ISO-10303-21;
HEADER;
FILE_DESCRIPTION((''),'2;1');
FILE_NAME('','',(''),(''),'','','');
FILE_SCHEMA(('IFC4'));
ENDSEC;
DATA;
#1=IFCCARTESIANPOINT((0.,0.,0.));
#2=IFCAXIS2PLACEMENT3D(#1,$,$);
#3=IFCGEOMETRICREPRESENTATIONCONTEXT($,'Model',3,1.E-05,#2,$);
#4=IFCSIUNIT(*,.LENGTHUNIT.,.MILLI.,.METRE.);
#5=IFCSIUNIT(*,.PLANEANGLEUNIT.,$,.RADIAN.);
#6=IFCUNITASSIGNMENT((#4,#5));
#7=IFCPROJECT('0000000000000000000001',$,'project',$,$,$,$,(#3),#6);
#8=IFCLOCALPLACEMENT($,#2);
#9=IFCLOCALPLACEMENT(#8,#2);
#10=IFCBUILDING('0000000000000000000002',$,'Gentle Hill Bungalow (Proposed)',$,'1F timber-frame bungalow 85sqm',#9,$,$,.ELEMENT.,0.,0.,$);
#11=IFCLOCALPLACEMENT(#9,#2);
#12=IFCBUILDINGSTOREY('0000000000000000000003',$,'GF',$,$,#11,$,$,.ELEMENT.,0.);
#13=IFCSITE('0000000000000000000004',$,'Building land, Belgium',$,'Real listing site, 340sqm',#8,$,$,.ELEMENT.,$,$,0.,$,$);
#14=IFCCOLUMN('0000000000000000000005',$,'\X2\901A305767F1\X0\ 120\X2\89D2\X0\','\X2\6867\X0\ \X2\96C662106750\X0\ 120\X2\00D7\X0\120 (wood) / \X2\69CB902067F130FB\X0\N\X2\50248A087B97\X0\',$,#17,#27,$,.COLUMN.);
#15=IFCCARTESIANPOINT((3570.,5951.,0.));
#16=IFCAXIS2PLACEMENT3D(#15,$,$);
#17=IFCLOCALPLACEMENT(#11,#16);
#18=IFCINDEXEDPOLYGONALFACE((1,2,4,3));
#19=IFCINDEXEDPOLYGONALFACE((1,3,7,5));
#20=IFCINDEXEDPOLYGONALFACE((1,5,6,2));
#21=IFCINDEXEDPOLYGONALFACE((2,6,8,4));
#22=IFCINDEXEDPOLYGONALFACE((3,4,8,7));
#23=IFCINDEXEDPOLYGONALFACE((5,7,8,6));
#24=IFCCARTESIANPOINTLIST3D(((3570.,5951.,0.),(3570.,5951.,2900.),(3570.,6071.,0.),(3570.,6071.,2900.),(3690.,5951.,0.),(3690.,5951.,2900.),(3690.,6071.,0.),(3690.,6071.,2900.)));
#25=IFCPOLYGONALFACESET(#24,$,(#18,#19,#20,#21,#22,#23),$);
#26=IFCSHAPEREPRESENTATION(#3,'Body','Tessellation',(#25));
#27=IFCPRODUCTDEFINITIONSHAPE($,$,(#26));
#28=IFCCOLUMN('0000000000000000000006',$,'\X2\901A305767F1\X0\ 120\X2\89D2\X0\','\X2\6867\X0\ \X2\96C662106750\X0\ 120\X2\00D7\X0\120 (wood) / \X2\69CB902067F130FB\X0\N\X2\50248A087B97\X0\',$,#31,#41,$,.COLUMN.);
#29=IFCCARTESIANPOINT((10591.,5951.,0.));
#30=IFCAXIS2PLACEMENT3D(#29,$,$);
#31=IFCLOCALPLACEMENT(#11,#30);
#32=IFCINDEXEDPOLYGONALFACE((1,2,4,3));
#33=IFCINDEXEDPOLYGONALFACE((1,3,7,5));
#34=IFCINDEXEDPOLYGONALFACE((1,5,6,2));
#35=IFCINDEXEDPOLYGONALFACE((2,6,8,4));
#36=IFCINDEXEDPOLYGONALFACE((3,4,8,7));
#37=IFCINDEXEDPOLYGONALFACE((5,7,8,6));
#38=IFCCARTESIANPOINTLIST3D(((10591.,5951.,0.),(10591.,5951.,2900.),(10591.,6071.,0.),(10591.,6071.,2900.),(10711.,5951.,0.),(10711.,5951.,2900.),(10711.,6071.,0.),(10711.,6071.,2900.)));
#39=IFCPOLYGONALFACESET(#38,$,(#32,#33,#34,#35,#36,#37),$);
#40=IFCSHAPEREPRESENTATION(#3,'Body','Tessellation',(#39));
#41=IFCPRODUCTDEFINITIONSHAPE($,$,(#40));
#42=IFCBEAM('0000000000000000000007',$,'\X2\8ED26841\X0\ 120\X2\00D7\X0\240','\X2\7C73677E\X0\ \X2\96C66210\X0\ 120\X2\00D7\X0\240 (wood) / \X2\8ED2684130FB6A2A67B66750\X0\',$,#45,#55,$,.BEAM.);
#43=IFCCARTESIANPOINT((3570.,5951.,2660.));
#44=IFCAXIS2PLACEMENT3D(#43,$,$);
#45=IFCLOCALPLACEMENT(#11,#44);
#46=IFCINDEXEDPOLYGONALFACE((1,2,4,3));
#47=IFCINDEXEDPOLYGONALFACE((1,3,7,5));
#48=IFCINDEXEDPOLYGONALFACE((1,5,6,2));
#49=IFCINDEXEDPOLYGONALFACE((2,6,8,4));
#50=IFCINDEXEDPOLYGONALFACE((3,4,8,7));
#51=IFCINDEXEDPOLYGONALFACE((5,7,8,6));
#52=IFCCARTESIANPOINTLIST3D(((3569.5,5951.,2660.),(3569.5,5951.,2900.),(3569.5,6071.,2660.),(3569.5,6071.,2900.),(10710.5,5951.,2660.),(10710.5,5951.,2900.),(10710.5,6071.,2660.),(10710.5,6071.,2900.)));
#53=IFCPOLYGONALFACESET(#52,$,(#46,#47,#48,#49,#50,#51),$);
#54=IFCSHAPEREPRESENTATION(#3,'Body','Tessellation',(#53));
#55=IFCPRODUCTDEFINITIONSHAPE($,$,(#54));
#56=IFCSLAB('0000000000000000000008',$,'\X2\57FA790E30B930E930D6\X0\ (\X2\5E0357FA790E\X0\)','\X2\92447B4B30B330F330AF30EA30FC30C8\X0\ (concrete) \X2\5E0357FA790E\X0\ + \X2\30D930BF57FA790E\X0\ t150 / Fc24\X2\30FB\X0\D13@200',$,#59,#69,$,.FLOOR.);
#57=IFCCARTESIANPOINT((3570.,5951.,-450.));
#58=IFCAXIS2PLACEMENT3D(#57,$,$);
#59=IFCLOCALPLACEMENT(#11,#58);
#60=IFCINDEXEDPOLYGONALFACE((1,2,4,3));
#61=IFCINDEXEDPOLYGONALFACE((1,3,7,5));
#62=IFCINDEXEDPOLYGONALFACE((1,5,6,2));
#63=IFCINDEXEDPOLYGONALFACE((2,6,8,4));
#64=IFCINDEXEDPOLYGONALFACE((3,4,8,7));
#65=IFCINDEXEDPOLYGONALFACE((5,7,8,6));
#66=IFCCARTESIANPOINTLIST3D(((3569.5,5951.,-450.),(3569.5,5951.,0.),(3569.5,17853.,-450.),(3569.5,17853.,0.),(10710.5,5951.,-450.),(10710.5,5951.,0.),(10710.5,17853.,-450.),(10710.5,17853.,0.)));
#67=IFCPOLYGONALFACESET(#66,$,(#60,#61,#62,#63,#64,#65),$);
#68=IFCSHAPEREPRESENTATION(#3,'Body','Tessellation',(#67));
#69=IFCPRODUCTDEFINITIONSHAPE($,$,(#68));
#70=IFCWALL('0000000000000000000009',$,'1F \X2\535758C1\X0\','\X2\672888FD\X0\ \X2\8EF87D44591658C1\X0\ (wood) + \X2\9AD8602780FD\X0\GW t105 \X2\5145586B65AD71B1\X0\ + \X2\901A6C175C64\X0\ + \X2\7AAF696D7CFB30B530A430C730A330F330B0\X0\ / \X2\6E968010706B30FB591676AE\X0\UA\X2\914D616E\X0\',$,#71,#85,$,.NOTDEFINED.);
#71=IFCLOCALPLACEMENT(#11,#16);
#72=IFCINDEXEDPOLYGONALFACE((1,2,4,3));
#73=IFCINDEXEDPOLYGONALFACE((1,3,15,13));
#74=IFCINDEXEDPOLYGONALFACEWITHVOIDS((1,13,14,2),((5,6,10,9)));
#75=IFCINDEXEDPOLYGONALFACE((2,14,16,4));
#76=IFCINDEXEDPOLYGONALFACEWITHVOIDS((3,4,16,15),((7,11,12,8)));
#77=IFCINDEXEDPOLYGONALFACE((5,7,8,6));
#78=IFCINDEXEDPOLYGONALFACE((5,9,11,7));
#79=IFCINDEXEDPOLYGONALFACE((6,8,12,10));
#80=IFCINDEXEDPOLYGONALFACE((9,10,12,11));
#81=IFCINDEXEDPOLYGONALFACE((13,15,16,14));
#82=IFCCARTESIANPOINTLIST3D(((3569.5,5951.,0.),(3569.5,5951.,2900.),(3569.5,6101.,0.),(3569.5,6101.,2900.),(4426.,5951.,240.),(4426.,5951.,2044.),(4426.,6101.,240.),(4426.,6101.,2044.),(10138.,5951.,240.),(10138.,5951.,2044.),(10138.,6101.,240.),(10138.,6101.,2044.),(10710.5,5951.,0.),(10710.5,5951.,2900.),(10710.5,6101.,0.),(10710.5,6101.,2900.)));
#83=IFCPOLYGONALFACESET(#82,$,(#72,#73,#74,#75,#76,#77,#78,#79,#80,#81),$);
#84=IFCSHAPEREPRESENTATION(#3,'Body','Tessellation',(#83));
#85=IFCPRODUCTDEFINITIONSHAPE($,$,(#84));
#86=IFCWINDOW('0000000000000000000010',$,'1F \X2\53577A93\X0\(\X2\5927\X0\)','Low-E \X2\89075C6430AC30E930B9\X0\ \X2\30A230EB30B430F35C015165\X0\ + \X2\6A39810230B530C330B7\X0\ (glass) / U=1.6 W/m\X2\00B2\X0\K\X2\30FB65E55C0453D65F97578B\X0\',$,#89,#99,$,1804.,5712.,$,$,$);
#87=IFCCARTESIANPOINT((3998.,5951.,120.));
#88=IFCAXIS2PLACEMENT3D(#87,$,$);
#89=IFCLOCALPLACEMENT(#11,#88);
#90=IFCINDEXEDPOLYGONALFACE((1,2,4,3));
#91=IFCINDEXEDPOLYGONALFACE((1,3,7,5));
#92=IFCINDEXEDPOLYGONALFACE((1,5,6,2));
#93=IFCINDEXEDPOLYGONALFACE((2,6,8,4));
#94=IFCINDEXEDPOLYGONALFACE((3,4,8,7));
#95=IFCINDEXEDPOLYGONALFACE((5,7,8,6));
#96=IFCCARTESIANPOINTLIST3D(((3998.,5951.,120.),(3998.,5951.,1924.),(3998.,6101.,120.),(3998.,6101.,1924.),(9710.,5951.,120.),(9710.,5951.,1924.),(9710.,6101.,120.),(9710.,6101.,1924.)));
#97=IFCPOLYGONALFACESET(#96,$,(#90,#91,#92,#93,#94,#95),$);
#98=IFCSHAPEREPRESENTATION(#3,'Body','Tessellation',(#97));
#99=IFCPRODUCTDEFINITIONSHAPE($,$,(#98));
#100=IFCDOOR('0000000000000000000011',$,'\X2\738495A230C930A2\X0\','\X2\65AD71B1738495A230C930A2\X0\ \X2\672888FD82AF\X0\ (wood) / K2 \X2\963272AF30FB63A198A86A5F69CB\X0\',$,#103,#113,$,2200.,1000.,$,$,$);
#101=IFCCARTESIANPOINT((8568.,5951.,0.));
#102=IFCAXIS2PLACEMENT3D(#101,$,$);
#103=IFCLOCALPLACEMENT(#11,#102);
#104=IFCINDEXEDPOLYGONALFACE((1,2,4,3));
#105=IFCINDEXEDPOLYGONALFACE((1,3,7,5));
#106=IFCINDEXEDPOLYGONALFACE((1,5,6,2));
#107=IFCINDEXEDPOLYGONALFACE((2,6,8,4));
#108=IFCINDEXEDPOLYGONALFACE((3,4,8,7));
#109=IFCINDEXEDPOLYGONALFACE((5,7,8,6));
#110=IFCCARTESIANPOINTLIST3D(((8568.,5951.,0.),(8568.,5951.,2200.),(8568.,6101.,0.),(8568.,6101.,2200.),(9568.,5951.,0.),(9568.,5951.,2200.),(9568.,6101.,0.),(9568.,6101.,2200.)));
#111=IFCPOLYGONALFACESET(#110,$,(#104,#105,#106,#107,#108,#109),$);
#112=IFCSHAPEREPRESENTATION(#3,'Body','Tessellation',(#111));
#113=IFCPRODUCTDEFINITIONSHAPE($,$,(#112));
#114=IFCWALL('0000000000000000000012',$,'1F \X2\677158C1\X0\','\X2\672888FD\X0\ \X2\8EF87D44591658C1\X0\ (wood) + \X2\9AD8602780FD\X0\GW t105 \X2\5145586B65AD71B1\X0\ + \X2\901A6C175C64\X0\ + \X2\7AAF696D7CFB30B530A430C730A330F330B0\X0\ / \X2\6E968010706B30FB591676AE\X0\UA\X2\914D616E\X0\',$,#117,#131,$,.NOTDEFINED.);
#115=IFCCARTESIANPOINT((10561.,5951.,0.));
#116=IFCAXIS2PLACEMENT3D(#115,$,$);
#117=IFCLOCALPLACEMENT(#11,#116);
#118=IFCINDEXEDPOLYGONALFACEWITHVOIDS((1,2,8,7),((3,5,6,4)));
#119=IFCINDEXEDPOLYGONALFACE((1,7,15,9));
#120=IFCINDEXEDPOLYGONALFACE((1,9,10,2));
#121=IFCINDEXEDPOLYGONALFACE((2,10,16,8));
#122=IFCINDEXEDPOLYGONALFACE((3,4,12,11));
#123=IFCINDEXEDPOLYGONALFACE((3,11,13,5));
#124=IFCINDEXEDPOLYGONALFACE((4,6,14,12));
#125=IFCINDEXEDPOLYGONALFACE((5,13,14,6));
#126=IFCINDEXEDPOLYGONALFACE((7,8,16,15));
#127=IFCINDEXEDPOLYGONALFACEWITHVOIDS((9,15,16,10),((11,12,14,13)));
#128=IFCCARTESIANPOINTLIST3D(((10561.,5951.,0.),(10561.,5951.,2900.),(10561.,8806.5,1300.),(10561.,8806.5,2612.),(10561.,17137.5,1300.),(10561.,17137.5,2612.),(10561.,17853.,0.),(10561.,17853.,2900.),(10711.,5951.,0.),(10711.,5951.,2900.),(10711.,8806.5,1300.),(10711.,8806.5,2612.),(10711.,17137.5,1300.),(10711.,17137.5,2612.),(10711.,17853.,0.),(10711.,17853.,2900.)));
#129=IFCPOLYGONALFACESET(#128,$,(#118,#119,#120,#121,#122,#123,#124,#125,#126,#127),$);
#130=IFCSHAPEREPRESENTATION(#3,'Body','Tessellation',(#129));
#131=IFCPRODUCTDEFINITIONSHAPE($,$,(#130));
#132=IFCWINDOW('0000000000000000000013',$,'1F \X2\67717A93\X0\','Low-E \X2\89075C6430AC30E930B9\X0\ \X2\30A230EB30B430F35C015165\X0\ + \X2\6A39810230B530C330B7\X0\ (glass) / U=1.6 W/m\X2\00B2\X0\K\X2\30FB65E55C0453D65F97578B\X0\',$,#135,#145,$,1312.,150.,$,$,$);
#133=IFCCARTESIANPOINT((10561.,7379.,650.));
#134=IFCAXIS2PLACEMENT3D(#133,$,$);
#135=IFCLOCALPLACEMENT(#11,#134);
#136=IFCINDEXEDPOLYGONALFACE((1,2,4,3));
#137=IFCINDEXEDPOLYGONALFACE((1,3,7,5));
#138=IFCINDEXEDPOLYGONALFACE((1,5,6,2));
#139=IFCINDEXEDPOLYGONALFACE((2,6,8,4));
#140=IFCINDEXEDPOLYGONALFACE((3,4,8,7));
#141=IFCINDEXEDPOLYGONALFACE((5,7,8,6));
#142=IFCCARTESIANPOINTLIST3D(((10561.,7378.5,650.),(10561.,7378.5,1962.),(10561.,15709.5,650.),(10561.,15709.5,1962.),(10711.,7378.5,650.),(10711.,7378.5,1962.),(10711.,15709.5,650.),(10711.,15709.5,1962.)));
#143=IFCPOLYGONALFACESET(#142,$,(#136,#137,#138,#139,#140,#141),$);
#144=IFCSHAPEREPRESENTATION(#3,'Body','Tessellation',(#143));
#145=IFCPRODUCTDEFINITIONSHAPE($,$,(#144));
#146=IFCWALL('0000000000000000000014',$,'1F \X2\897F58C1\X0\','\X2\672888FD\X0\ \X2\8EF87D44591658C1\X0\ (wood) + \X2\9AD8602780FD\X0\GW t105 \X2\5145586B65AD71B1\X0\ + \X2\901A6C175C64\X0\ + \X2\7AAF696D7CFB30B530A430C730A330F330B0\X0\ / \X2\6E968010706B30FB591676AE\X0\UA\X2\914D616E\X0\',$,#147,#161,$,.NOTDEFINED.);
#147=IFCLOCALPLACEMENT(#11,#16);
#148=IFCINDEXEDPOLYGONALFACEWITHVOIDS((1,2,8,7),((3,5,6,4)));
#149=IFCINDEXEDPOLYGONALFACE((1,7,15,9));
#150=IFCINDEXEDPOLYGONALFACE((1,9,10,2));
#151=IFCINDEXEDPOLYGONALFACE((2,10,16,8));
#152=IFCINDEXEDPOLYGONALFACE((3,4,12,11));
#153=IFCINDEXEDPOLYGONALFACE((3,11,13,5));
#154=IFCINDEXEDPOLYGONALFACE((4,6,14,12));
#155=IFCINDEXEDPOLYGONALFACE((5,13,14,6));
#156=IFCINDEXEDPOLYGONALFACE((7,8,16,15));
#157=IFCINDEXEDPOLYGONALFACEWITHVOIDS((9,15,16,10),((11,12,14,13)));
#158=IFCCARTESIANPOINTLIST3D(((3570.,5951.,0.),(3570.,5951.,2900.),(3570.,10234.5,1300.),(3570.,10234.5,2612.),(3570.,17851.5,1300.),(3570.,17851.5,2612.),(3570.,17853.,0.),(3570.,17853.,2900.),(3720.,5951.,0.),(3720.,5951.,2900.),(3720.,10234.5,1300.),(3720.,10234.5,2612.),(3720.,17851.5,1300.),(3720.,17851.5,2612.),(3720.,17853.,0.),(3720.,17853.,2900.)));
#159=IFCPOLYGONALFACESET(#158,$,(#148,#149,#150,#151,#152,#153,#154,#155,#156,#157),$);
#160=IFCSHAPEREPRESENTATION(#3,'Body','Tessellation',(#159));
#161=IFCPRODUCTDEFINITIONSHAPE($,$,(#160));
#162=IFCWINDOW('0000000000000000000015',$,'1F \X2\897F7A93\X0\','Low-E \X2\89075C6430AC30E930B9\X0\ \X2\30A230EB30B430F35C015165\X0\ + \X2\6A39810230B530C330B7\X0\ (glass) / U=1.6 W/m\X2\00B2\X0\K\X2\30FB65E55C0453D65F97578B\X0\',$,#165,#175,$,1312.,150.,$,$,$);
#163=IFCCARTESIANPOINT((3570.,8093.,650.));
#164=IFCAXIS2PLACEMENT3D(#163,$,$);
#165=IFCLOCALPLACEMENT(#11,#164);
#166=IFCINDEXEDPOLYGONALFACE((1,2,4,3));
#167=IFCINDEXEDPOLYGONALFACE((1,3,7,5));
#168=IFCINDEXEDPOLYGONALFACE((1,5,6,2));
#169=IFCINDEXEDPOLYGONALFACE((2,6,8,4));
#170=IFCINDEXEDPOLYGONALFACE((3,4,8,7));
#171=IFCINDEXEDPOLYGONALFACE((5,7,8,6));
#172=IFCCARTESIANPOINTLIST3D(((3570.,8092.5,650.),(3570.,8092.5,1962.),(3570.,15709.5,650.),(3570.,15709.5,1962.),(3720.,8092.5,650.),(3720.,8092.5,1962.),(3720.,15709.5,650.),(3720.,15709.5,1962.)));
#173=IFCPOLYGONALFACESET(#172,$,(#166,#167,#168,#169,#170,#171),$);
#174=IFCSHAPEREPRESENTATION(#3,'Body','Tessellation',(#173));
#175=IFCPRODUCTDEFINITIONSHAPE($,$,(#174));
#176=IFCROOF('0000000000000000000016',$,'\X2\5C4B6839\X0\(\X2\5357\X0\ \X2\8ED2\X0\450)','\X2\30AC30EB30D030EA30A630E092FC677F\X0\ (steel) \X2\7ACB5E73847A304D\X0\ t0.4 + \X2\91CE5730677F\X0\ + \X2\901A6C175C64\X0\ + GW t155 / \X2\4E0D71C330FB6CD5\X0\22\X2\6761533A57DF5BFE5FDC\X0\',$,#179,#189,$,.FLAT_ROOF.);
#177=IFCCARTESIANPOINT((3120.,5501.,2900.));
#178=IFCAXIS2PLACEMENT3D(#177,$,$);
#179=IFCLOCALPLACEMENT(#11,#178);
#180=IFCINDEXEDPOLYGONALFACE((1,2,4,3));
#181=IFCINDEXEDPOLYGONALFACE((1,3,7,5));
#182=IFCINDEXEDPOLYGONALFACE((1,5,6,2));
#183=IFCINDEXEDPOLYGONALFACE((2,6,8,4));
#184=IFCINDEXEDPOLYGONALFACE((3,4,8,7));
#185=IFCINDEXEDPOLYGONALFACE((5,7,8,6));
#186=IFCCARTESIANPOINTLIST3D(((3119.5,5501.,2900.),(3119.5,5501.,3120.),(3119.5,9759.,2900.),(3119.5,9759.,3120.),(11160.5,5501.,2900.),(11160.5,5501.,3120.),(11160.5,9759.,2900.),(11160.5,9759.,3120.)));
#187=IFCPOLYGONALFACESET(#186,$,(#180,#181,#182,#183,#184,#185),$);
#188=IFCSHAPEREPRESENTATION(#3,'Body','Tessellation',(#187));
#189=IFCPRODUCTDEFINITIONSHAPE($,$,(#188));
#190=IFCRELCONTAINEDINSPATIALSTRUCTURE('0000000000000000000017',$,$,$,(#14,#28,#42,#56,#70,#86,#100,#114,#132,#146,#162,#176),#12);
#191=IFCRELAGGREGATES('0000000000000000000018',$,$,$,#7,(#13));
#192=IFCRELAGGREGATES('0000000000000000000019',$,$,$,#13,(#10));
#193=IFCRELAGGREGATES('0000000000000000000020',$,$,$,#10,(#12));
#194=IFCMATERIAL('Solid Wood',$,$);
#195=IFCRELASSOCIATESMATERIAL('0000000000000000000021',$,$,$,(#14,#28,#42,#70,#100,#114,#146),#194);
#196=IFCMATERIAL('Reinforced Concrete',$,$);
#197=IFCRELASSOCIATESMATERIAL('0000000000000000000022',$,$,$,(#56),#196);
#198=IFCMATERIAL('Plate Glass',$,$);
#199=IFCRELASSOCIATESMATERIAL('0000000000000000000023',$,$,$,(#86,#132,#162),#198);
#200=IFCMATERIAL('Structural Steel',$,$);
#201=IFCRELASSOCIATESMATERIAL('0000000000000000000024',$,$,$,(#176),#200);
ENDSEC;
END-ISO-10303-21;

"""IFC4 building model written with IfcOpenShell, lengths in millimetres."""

from ifc_helpers import new_model, si_unit, frame, frame_2d, origin, place, context, project, spatial, rectangle, extrude, material, element, fill, save


model = new_model("IFC4")

# Units and contexts
model_context = context("Model", 3, precision=1e-05, world=origin())
ifc_project = project(units=[si_unit("LENGTHUNIT", "METRE", prefix="MILLI"), si_unit("PLANEANGLEUNIT", "RADIAN")], contexts=[model_context])

# Site, building, storey
site_placement = place(None, origin())
site = spatial("IfcSite", under=ifc_project, at=site_placement, Name="Building land, Belgium", ObjectType="Real listing site, 340sqm", CompositionType="ELEMENT", RefElevation=0.0)
building_placement = place(site_placement, origin())
building = spatial("IfcBuilding", under=site, at=building_placement, Name="Gentle Hill Bungalow (Proposed)", ObjectType="1F timber-frame bungalow 85sqm", CompositionType="ELEMENT", ElevationOfRefHeight=0.0, ElevationOfTerrain=0.0)
storey_placement = place(building_placement, origin())
storey = spatial("IfcBuildingStorey", under=building, at=storey_placement, Name="GF", CompositionType="ELEMENT", Elevation=0.0)

# Columns
ifc_material_1 = material(Name="Solid Wood")
column_1_placement = place(storey_placement, frame((3570.0, 5951.0, 0.0)))
element("IfcColumn", 1, at=column_1_placement, inside=storey, material=ifc_material_1, Name="通し柱 120角", Description="桧 集成材 120×120 (wood) / 構造柱・N値計算", PredefinedType="COLUMN", context=model_context, shape_type="SweptSolid", body=[
    extrude(rectangle(XDim=120.0, YDim=120.0, at=frame_2d((60.0, 60.0))), frame((3570.0, 5951.0, 0.0)), (0.0, 0.0, 1.0), 2900.0),
])
column_2_placement = place(storey_placement, frame((10591.0, 5951.0, 0.0)))
element("IfcColumn", 2, at=column_2_placement, inside=storey, material=ifc_material_1, Name="通し柱 120角", Description="桧 集成材 120×120 (wood) / 構造柱・N値計算", PredefinedType="COLUMN", context=model_context, shape_type="SweptSolid", body=[
    extrude(rectangle(XDim=120.0, YDim=120.0, at=frame_2d((60.0, 60.0))), frame((10591.0, 5951.0, 0.0)), (0.0, 0.0, 1.0), 2900.0),
])

# Beam
beam_1_placement = place(storey_placement, frame((3570.0, 5951.0, 2660.0)))
element("IfcBeam", 3, at=beam_1_placement, inside=storey, material=ifc_material_1, Name="軒桁 120×240", Description="米松 集成 120×240 (wood) / 軒桁・横架材", PredefinedType="BEAM", context=model_context, shape_type="SweptSolid", body=[
    extrude(rectangle(XDim=7141.0, YDim=120.0, at=frame_2d((3570.0, 60.0))), frame((3570.0, 5951.0, 2660.0)), (0.0, 0.0, 1.0), 240.0),
])

# Slab
ifc_material_2 = material(Name="Reinforced Concrete")
slab_1_placement = place(storey_placement, frame((3570.0, 5951.0, -450.0)))
element("IfcSlab", 4, at=slab_1_placement, inside=storey, material=ifc_material_2, Name="基礎スラブ (布基礎)", Description="鉄筋コンクリート (concrete) 布基礎 + ベタ基礎 t150 / Fc24・D13@200", PredefinedType="FLOOR", context=model_context, shape_type="SweptSolid", body=[
    extrude(rectangle(XDim=7141.0, YDim=11902.0, at=frame_2d((3570.0, 5951.0))), frame((3570.0, 5951.0, -450.0)), (0.0, 0.0, 1.0), 450.0),
])

# Wall, openings, window, door
wall_1_placement = place(storey_placement, frame((3570.0, 5951.0, 0.0)))
wall_1 = element("IfcWall", 5, at=wall_1_placement, inside=storey, material=ifc_material_1, Name="1F 南壁", Description="木製 軸組外壁 (wood) + 高性能GW t105 充填断熱 + 通気層 + 窯業系サイディング / 準耐火・外皮UA配慮", PredefinedType="NOTDEFINED", context=model_context, shape_type="SweptSolid", body=[
    extrude(rectangle(XDim=7141.0, YDim=150.0, at=frame_2d((3570.0, 75.0))), frame((3570.0, 5951.0, 0.0)), (0.0, 0.0, 1.0), 2900.0),
])
opening_1_placement = place(storey_placement, frame((3998.0, 5951.0, 120.0)))
opening_1 = element("IfcOpeningElement", 6, at=opening_1_placement, cuts=wall_1, PredefinedType="NOTDEFINED", context=model_context, shape_type="SweptSolid", body=[
    extrude(rectangle(XDim=5712.0, YDim=150.0, at=frame_2d((2856.0, 75.0))), frame((3998.0, 5951.0, 120.0)), (0.0, 0.0, 1.0), 1804.0),
])
opening_2_placement = place(storey_placement, frame((8568.0, 5951.0, 0.0)))
opening_2 = element("IfcOpeningElement", 7, at=opening_2_placement, cuts=wall_1, PredefinedType="NOTDEFINED", context=model_context, shape_type="SweptSolid", body=[
    extrude(rectangle(XDim=1000.0, YDim=150.0, at=frame_2d((500.0, 75.0))), frame((8568.0, 5951.0, 0.0)), (0.0, 0.0, 1.0), 2200.0),
])
ifc_material_3 = material(Name="Plate Glass")
window_1_placement = place(storey_placement, frame((3998.0, 5951.0, 120.0)))
window_1 = element("IfcWindow", 8, at=window_1_placement, inside=storey, material=ifc_material_3, Name="1F 南窓(大)", Description="Low-E 複層ガラス アルゴン封入 + 樹脂サッシ (glass) / U=1.6 W/m²K・日射取得型", OverallHeight=1804.0, OverallWidth=5712.0, context=model_context, shape_type="SweptSolid", body=[
    extrude(rectangle(XDim=5712.0, YDim=150.0, at=frame_2d((2856.0, 75.0))), frame((3998.0, 5951.0, 120.0)), (0.0, 0.0, 1.0), 1804.0),
])
fill(opening_1, window_1)
door_placement = place(storey_placement, frame((8568.0, 5951.0, 0.0)))
door = element("IfcDoor", 9, at=door_placement, inside=storey, material=ifc_material_1, Name="玄関ドア", Description="断熱玄関ドア 木製芯 (wood) / K2 防犯・採風機構", OverallHeight=2200.0, OverallWidth=1000.0, context=model_context, shape_type="SweptSolid", body=[
    extrude(rectangle(XDim=1000.0, YDim=150.0, at=frame_2d((500.0, 75.0))), frame((8568.0, 5951.0, 0.0)), (0.0, 0.0, 1.0), 2200.0),
])
fill(opening_2, door)

# Walls, openings, windows
wall_2_placement = place(storey_placement, frame((10561.0, 5951.0, 0.0)))
wall_2 = element("IfcWall", 10, at=wall_2_placement, inside=storey, material=ifc_material_1, Name="1F 東壁", Description="木製 軸組外壁 (wood) + 高性能GW t105 充填断熱 + 通気層 + 窯業系サイディング / 準耐火・外皮UA配慮", PredefinedType="NOTDEFINED", context=model_context, shape_type="SweptSolid", body=[
    extrude(rectangle(XDim=150.0, YDim=11902.0, at=frame_2d((75.0, 5951.0))), frame((10561.0, 5951.0, 0.0)), (0.0, 0.0, 1.0), 2900.0),
])
opening_3_placement = place(storey_placement, frame((10561.0, 7379.0, 650.0)))
opening_3 = element("IfcOpeningElement", 11, at=opening_3_placement, cuts=wall_2, PredefinedType="NOTDEFINED", context=model_context, shape_type="SweptSolid", body=[
    extrude(rectangle(XDim=150.0, YDim=8331.0, at=frame_2d((75.0, 4165.0))), frame((10561.0, 7379.0, 650.0)), (0.0, 0.0, 1.0), 1312.0),
])
window_2_placement = place(storey_placement, frame((10561.0, 7379.0, 650.0)))
window_2 = element("IfcWindow", 12, at=window_2_placement, inside=storey, material=ifc_material_3, Name="1F 東窓", Description="Low-E 複層ガラス アルゴン封入 + 樹脂サッシ (glass) / U=1.6 W/m²K・日射取得型", OverallHeight=1312.0, OverallWidth=150.0, context=model_context, shape_type="SweptSolid", body=[
    extrude(rectangle(XDim=150.0, YDim=8331.0, at=frame_2d((75.0, 4165.0))), frame((10561.0, 7379.0, 650.0)), (0.0, 0.0, 1.0), 1312.0),
])
fill(opening_3, window_2)
wall_3_placement = place(storey_placement, frame((3570.0, 5951.0, 0.0)))
wall_3 = element("IfcWall", 13, at=wall_3_placement, inside=storey, material=ifc_material_1, Name="1F 西壁", Description="木製 軸組外壁 (wood) + 高性能GW t105 充填断熱 + 通気層 + 窯業系サイディング / 準耐火・外皮UA配慮", PredefinedType="NOTDEFINED", context=model_context, shape_type="SweptSolid", body=[
    extrude(rectangle(XDim=150.0, YDim=11902.0, at=frame_2d((75.0, 5951.0))), frame((3570.0, 5951.0, 0.0)), (0.0, 0.0, 1.0), 2900.0),
])
opening_4_placement = place(storey_placement, frame((3570.0, 8093.0, 650.0)))
opening_4 = element("IfcOpeningElement", 14, at=opening_4_placement, cuts=wall_3, PredefinedType="NOTDEFINED", context=model_context, shape_type="SweptSolid", body=[
    extrude(rectangle(XDim=150.0, YDim=7617.0, at=frame_2d((75.0, 3808.0))), frame((3570.0, 8093.0, 650.0)), (0.0, 0.0, 1.0), 1312.0),
])
window_3_placement = place(storey_placement, frame((3570.0, 8093.0, 650.0)))
window_3 = element("IfcWindow", 15, at=window_3_placement, inside=storey, material=ifc_material_3, Name="1F 西窓", Description="Low-E 複層ガラス アルゴン封入 + 樹脂サッシ (glass) / U=1.6 W/m²K・日射取得型", OverallHeight=1312.0, OverallWidth=150.0, context=model_context, shape_type="SweptSolid", body=[
    extrude(rectangle(XDim=150.0, YDim=7617.0, at=frame_2d((75.0, 3808.0))), frame((3570.0, 8093.0, 650.0)), (0.0, 0.0, 1.0), 1312.0),
])
fill(opening_4, window_3)

# Roof
ifc_material_4 = material(Name="Structural Steel")
roof_placement = place(storey_placement, frame((3120.0, 5501.0, 2900.0)))
element("IfcRoof", 16, at=roof_placement, inside=storey, material=ifc_material_4, Name="屋根(南 軒450)", Description="ガルバリウム鋼板 (steel) 立平葺き t0.4 + 野地板 + 通気層 + GW t155 / 不燃・法22条区域対応", PredefinedType="FLAT_ROOF", context=model_context, shape_type="SweptSolid", body=[
    extrude(rectangle(XDim=8041.0, YDim=4258.0, at=frame_2d((4020.0, 2129.0))), frame((3120.0, 5501.0, 2900.0)), (0.0, 0.0, 1.0), 220.0),
])

save(model, "model.ifc")
